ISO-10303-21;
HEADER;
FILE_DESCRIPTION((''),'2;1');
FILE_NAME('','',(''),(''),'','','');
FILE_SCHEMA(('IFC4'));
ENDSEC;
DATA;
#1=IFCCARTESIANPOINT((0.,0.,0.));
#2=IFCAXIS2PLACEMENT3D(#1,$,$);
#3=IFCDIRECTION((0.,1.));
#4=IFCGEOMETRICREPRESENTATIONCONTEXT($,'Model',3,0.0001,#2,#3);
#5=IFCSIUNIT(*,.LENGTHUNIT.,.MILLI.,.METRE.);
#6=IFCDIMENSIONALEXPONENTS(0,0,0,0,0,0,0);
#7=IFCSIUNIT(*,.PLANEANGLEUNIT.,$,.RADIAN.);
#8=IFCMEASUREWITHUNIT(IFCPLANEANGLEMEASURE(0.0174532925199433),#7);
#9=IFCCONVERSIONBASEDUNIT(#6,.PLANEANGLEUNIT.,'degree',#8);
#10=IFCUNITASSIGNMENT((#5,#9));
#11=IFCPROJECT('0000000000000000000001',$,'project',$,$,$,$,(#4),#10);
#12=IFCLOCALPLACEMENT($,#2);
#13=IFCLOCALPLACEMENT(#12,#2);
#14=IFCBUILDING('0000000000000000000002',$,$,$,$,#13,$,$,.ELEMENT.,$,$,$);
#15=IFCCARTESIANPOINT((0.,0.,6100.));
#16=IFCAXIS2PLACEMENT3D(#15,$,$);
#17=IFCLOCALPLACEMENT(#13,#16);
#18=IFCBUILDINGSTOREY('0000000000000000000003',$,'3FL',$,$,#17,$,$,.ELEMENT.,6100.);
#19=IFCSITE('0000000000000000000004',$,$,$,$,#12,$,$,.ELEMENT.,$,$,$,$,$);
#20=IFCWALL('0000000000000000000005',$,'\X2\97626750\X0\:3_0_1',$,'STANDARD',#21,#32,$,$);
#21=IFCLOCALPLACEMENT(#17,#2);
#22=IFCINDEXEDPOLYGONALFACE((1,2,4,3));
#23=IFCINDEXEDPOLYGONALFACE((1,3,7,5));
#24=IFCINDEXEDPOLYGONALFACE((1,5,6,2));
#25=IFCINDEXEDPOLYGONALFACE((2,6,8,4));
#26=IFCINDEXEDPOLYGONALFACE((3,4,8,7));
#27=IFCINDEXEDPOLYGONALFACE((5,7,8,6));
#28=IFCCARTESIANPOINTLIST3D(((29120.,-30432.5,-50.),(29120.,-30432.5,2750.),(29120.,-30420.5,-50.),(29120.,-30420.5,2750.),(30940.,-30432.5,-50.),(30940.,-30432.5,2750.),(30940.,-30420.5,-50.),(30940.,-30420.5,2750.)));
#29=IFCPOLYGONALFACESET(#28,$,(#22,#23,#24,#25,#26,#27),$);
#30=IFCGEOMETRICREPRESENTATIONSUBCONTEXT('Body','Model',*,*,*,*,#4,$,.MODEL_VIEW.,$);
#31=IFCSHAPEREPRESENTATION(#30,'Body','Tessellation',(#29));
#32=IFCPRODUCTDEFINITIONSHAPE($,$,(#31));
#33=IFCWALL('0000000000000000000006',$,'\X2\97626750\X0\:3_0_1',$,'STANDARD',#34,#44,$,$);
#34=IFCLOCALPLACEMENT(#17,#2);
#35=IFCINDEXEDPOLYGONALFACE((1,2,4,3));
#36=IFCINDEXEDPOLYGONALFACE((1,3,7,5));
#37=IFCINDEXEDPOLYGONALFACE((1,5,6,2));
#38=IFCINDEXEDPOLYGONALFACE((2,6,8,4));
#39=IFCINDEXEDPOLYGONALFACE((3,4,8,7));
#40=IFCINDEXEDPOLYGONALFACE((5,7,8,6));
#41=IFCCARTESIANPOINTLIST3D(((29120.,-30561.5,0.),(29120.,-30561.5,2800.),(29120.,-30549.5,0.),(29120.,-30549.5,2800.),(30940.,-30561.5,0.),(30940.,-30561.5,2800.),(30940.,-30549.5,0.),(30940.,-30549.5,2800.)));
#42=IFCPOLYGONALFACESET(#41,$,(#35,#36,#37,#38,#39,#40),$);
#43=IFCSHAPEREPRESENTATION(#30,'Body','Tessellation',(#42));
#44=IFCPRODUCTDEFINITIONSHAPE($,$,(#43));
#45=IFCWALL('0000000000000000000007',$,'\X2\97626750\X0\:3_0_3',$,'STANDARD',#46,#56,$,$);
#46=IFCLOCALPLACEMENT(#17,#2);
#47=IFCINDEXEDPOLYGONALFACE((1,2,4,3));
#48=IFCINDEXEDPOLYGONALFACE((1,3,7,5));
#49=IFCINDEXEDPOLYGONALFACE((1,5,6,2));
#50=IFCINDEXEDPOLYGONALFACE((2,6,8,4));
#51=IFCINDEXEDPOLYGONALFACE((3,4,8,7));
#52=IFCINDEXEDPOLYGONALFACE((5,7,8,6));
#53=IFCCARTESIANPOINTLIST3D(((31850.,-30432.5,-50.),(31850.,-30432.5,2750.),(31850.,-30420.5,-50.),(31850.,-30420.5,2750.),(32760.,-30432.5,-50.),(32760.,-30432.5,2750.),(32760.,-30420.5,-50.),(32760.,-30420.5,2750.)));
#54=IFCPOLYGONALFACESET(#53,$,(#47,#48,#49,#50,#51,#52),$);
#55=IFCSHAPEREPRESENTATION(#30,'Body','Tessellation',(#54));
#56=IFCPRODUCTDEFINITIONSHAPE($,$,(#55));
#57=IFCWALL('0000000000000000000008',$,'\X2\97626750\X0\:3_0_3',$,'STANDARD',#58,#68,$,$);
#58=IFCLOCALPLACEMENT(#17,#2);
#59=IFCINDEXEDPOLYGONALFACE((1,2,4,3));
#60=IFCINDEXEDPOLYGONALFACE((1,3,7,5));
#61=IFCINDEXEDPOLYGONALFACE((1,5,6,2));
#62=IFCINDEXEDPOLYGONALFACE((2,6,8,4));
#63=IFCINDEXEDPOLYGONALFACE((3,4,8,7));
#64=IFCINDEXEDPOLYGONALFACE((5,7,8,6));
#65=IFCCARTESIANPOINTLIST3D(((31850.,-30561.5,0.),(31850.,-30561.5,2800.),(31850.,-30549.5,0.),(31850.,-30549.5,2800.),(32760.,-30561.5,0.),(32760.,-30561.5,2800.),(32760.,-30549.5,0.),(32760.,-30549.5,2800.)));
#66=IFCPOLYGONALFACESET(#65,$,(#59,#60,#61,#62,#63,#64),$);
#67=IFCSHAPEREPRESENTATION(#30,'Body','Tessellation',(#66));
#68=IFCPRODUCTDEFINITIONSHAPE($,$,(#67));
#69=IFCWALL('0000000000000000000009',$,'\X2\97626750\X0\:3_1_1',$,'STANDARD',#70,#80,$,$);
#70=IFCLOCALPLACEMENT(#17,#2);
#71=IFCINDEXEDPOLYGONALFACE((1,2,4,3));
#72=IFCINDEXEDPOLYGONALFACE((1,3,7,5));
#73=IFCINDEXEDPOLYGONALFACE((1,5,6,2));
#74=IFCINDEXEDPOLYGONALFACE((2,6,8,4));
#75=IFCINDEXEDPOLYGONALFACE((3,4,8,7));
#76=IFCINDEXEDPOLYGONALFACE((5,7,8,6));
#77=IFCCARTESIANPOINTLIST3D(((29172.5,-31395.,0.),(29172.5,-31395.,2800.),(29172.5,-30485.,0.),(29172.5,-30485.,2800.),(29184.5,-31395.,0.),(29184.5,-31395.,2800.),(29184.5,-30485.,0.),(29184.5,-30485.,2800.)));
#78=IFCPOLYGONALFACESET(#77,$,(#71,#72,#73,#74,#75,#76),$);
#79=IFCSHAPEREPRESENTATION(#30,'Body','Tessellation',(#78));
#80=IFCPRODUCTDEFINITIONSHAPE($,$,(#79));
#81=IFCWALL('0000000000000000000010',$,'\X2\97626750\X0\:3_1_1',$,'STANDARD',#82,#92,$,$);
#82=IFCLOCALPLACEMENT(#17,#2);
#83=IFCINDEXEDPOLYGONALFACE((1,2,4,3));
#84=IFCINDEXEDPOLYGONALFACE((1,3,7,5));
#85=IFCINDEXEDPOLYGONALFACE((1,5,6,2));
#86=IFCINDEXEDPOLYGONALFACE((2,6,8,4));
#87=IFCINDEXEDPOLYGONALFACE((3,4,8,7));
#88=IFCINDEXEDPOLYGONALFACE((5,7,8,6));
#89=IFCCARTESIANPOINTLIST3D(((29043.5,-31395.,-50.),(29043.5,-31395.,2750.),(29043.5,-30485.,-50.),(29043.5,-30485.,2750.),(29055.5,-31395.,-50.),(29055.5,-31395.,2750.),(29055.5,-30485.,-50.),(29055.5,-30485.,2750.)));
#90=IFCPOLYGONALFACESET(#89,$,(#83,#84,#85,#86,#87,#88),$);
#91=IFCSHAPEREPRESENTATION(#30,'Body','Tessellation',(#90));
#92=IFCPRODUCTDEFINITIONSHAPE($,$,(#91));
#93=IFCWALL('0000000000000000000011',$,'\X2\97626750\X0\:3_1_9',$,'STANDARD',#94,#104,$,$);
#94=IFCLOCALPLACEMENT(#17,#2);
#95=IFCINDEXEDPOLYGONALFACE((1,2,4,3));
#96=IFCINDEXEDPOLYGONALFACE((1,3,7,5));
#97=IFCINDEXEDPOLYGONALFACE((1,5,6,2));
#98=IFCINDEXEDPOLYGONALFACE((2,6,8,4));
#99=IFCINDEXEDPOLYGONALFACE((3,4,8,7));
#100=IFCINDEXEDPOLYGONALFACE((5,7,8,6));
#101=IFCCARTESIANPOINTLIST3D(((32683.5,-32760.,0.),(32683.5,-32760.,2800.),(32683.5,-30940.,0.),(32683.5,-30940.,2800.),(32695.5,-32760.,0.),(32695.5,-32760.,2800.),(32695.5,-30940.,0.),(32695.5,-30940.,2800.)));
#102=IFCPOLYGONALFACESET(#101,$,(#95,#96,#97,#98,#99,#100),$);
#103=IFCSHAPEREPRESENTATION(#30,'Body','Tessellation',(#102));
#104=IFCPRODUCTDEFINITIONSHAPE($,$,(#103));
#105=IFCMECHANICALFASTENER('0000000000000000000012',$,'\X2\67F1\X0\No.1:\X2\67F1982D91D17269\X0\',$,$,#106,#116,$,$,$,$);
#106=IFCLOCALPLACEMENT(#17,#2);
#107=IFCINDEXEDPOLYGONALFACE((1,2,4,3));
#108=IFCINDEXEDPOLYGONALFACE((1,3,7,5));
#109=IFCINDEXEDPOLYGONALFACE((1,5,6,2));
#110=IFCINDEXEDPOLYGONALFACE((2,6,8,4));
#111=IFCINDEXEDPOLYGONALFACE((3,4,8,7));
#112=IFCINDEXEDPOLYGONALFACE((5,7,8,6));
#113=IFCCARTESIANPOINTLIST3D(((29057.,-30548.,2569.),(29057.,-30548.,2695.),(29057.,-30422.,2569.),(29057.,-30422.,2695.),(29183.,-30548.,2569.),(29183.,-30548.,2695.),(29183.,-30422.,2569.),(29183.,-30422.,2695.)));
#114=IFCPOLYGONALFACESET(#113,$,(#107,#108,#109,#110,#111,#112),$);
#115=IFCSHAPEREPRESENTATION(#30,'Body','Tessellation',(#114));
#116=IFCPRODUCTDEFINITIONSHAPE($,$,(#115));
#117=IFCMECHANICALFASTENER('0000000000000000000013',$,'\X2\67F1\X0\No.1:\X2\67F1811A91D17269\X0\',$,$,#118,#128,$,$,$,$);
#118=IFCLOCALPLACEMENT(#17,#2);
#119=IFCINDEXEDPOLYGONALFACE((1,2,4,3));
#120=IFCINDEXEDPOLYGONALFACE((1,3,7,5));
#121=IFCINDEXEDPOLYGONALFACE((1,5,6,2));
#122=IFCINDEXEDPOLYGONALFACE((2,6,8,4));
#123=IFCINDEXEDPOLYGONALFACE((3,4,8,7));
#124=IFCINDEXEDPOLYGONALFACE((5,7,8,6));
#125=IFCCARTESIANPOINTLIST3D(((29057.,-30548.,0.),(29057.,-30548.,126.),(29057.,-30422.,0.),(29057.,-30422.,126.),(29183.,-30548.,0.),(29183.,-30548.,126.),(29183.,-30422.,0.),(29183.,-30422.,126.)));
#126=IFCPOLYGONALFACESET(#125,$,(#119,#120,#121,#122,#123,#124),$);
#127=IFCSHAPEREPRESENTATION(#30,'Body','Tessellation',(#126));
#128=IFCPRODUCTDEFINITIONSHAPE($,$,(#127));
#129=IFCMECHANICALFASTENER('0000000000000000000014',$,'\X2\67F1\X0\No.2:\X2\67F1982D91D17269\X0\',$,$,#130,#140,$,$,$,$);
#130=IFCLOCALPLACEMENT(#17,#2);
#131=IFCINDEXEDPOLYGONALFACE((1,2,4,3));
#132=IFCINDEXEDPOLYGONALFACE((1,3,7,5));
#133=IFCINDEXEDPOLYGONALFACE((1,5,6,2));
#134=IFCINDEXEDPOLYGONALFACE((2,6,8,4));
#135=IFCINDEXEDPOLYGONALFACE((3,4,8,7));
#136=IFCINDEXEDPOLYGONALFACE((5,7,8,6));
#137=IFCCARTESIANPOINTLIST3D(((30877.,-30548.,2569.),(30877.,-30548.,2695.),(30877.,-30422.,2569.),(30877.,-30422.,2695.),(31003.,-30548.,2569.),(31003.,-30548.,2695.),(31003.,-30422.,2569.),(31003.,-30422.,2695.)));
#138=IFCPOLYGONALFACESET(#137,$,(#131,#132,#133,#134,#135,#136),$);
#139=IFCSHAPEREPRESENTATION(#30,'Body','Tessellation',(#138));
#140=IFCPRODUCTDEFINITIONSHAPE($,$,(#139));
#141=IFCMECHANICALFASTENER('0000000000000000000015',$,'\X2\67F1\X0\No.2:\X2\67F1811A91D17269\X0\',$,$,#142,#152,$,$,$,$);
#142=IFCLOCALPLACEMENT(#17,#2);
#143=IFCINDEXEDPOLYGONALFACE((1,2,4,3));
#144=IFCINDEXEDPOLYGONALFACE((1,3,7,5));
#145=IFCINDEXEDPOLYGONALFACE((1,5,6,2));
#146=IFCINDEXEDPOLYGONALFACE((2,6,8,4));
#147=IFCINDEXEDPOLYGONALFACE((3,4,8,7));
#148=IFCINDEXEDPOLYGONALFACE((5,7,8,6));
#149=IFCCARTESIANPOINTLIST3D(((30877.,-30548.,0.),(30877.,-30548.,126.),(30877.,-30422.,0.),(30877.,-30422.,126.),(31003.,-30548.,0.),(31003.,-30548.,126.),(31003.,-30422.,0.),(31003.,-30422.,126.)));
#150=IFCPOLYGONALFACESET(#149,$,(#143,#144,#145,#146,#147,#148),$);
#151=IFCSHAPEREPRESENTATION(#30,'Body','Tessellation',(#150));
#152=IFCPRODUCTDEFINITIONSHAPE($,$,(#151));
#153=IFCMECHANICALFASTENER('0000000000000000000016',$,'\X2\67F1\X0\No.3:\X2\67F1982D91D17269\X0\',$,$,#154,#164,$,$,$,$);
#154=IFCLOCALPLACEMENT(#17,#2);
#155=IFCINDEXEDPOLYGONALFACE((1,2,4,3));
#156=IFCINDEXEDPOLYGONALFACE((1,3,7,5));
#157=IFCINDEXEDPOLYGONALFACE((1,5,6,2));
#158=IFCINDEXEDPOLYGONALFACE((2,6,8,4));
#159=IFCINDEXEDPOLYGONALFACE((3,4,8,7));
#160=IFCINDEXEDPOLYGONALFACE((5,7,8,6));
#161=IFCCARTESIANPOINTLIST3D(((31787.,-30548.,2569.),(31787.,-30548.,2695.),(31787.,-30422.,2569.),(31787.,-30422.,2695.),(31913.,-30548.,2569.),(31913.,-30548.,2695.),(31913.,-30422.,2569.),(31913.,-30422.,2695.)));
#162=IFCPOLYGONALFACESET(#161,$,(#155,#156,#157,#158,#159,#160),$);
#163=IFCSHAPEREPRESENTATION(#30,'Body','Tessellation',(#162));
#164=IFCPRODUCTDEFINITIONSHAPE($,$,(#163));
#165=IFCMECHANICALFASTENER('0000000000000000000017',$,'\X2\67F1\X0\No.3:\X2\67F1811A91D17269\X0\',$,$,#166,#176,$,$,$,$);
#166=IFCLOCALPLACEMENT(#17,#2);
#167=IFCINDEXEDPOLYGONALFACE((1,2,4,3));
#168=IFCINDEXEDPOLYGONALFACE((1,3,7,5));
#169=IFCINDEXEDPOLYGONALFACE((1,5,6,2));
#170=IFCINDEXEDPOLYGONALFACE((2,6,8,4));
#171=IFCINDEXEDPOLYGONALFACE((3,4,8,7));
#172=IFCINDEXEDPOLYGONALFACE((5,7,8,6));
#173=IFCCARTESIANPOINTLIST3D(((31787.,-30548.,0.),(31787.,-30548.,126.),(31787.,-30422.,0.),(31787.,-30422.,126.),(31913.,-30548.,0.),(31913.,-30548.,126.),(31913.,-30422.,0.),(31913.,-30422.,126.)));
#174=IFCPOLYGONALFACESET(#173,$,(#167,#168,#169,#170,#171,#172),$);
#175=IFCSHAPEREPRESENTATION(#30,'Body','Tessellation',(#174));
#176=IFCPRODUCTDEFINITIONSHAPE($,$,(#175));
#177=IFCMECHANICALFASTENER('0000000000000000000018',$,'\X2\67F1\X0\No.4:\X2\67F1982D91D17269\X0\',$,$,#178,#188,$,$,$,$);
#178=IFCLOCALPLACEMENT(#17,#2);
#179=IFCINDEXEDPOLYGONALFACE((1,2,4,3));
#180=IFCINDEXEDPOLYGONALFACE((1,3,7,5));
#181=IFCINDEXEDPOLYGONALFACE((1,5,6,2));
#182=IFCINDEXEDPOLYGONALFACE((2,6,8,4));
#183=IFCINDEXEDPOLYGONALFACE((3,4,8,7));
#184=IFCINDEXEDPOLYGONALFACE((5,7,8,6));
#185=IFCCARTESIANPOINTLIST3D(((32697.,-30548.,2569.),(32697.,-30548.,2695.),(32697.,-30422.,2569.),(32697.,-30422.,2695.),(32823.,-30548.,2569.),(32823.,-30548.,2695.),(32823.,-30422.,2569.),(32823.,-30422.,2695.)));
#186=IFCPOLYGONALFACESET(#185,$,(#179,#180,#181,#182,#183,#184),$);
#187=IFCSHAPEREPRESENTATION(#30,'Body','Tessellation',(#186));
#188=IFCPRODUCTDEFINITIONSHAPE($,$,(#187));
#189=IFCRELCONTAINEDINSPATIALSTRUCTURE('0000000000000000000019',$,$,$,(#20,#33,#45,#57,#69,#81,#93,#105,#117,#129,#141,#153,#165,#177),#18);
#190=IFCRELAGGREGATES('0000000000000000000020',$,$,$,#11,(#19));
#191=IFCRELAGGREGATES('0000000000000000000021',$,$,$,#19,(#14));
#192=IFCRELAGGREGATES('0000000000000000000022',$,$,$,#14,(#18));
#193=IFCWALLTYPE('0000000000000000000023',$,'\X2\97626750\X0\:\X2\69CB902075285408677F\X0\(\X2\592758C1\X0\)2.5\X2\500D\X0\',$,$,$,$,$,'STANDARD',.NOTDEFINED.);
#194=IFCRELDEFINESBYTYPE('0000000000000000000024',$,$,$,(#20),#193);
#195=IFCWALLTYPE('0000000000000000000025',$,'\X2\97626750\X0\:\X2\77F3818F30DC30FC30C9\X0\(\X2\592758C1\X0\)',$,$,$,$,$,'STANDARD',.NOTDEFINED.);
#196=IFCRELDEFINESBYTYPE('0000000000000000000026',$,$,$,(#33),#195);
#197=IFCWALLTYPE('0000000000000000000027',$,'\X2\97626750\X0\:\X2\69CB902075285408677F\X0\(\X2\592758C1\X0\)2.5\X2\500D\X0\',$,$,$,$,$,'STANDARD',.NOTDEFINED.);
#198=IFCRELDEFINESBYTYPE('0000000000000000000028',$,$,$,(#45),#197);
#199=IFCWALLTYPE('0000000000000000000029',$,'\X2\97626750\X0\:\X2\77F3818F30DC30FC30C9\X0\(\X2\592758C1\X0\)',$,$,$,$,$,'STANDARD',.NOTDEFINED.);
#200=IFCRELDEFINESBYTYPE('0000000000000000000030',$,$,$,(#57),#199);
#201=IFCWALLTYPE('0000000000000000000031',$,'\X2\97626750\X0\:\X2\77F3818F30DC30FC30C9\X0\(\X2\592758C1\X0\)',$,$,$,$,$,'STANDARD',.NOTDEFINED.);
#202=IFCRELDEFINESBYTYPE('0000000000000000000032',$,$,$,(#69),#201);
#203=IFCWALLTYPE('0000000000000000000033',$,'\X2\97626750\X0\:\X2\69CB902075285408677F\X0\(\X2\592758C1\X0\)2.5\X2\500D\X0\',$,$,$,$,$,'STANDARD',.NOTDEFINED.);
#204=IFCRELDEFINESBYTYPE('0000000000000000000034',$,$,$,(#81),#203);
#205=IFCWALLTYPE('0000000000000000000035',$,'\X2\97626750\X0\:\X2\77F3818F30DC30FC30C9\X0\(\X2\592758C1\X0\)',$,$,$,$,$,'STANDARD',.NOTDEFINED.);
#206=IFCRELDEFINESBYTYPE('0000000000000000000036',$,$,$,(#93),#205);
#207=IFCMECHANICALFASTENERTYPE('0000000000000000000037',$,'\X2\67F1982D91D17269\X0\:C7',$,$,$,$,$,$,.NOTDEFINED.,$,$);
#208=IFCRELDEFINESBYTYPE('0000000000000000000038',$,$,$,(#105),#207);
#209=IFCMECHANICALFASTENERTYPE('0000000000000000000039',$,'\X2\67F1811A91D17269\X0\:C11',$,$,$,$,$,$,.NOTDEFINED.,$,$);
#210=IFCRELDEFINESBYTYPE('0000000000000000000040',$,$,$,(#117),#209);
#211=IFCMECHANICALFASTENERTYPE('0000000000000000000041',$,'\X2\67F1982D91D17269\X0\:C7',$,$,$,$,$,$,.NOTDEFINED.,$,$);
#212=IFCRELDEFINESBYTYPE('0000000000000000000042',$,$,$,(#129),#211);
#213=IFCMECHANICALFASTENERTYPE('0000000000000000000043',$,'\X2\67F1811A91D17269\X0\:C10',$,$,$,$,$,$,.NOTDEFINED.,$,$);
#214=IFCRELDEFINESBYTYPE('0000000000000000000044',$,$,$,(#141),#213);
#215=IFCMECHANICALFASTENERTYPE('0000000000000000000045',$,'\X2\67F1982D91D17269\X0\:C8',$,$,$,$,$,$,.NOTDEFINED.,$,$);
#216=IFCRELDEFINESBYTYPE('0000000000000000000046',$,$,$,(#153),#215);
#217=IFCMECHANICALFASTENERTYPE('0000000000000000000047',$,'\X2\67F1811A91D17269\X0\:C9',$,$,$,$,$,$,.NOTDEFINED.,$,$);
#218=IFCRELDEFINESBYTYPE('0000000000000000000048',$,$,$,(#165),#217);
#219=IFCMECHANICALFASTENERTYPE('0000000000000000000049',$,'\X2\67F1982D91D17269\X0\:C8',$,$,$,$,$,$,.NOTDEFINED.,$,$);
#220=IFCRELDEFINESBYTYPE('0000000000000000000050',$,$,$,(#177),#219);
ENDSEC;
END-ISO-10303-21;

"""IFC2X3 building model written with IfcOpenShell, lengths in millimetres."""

from ifc_helpers import new_model, entity, si_unit, converted_unit, direction, frame, origin, origin_with_axes, origin_2d, place, context, subcontext, project, spatial, polyline, rectangle, outline, extrude, type_object, element, save


model = new_model("IFC2X3")

# Units and contexts
model_context = context("Model", 3, precision=0.0001, world=origin(), true_north=direction((0.0, 1.0)))
body_context = subcontext(model_context, "Body", "Model", "MODEL_VIEW")
ifc_project = project(units=[si_unit("LENGTHUNIT", "METRE", prefix="MILLI"), converted_unit("PLANEANGLEUNIT", "degree", entity("IfcPlaneAngleMeasure", 0.0174532925199433), si_unit("PLANEANGLEUNIT", "RADIAN"), dimensions=[0, 0, 0, 0, 0, 0, 0])], contexts=[model_context])

# Site, building, storey
site_placement = place(None, origin())
site = spatial("IfcSite", under=ifc_project, at=site_placement, CompositionType="ELEMENT")
building_placement = place(site_placement, origin())
building = spatial("IfcBuilding", under=site, at=building_placement, CompositionType="ELEMENT")
storey_placement = place(building_placement, frame((0.0, 0.0, 6100.0)))
storey = spatial("IfcBuildingStorey", under=building, at=storey_placement, Name="3FL", CompositionType="ELEMENT", Elevation=6100.0)

# Walls
wall_type_1 = type_object("IfcWallType", Name="面材:構造用合板(大壁)2.5倍", ElementType="STANDARD", PredefinedType="NOTDEFINED")
wall_1_placement = place(storey_placement, frame((30030.0, -30420.5, -50.0), z_axis=(0.0, -1.0, 0.0), x_axis=(1.0, 0.0, 0.0)))
element("IfcWall", 1, at=wall_1_placement, inside=storey, type_object=wall_type_1, Name="面材:3_0_1", ObjectType="STANDARD", context=body_context, shape_type="SweptSolid", body=[
    extrude(outline(polyline([(910.0, 0.0, 0.0), (-910.0, 0.0, 0.0), (-910.0, 2800.0, 0.0), (910.0, 2800.0, 0.0), (910.0, 0.0, 0.0)])), origin_with_axes(), (0.0, 0.0, 1.0), 12.0),
])
wall_type_2 = type_object("IfcWallType", Name="面材:石膏ボード(大壁)", ElementType="STANDARD", PredefinedType="NOTDEFINED")
wall_2_placement = place(storey_placement, frame((30030.0, -30549.5, 0.0), z_axis=(0.0, -1.0, 0.0), x_axis=(1.0, 0.0, 0.0)))
element("IfcWall", 2, at=wall_2_placement, inside=storey, type_object=wall_type_2, Name="面材:3_0_1", ObjectType="STANDARD", context=body_context, shape_type="SweptSolid", body=[
    extrude(outline(polyline([(910.0, 0.0, 0.0), (-910.0, 0.0, 0.0), (-910.0, 2800.0, 0.0), (910.0, 2800.0, 0.0), (910.0, 0.0, 0.0)])), origin_with_axes(), (0.0, 0.0, 1.0), 12.0),
])
wall_type_3 = type_object("IfcWallType", Name="面材:構造用合板(大壁)2.5倍", ElementType="STANDARD", PredefinedType="NOTDEFINED")
wall_3_placement = place(storey_placement, frame((32305.0, -30420.5, -50.0), z_axis=(0.0, -1.0, 0.0), x_axis=(1.0, 0.0, 0.0)))
element("IfcWall", 3, at=wall_3_placement, inside=storey, type_object=wall_type_3, Name="面材:3_0_3", ObjectType="STANDARD", context=body_context, shape_type="SweptSolid", body=[
    extrude(outline(polyline([(455.0, 0.0, 0.0), (-455.0, 0.0, 0.0), (-455.0, 2800.0, 0.0), (455.0, 2800.0, 0.0), (455.0, 0.0, 0.0)])), origin_with_axes(), (0.0, 0.0, 1.0), 12.0),
])
wall_type_4 = type_object("IfcWallType", Name="面材:石膏ボード(大壁)", ElementType="STANDARD", PredefinedType="NOTDEFINED")
wall_4_placement = place(storey_placement, frame((32305.0, -30549.5, 0.0), z_axis=(0.0, -1.0, 0.0), x_axis=(1.0, 0.0, 0.0)))
element("IfcWall", 4, at=wall_4_placement, inside=storey, type_object=wall_type_4, Name="面材:3_0_3", ObjectType="STANDARD", context=body_context, shape_type="SweptSolid", body=[
    extrude(outline(polyline([(455.0, 0.0, 0.0), (-455.0, 0.0, 0.0), (-455.0, 2800.0, 0.0), (455.0, 2800.0, 0.0), (455.0, 0.0, 0.0)])), origin_with_axes(), (0.0, 0.0, 1.0), 12.0),
])
wall_type_5 = type_object("IfcWallType", Name="面材:石膏ボード(大壁)", ElementType="STANDARD", PredefinedType="NOTDEFINED")
wall_5_placement = place(storey_placement, frame((29184.5, -30940.0, 0.0), z_axis=(-1.0, 0.0, 0.0), x_axis=(0.0, -1.0, 0.0)))
element("IfcWall", 5, at=wall_5_placement, inside=storey, type_object=wall_type_5, Name="面材:3_1_1", ObjectType="STANDARD", context=body_context, shape_type="SweptSolid", body=[
    extrude(outline(polyline([(455.0, 0.0, 0.0), (-455.0, 0.0, 0.0), (-455.0, 2800.0, 0.0), (455.0, 2800.0, 0.0), (455.0, 0.0, 0.0)])), origin_with_axes(), (0.0, 0.0, 1.0), 12.0),
])
wall_type_6 = type_object("IfcWallType", Name="面材:構造用合板(大壁)2.5倍", ElementType="STANDARD", PredefinedType="NOTDEFINED")
wall_6_placement = place(storey_placement, frame((29055.5, -30940.0, -50.0), z_axis=(-1.0, 0.0, 0.0), x_axis=(0.0, -1.0, 0.0)))
element("IfcWall", 6, at=wall_6_placement, inside=storey, type_object=wall_type_6, Name="面材:3_1_1", ObjectType="STANDARD", context=body_context, shape_type="SweptSolid", body=[
    extrude(outline(polyline([(455.0, 0.0, 0.0), (-455.0, 0.0, 0.0), (-455.0, 2800.0, 0.0), (455.0, 2800.0, 0.0), (455.0, 0.0, 0.0)])), origin_with_axes(), (0.0, 0.0, 1.0), 12.0),
])
wall_type_7 = type_object("IfcWallType", Name="面材:石膏ボード(大壁)", ElementType="STANDARD", PredefinedType="NOTDEFINED")
wall_7_placement = place(storey_placement, frame((32695.5, -31850.0, 0.0), z_axis=(-1.0, 0.0, 0.0), x_axis=(0.0, -1.0, 0.0)))
element("IfcWall", 7, at=wall_7_placement, inside=storey, type_object=wall_type_7, Name="面材:3_1_9", ObjectType="STANDARD", context=body_context, shape_type="SweptSolid", body=[
    extrude(outline(polyline([(910.0, 0.0, 0.0), (-910.0, 0.0, 0.0), (-910.0, 2800.0, 0.0), (910.0, 2800.0, 0.0), (910.0, 0.0, 0.0)])), origin_with_axes(), (0.0, 0.0, 1.0), 12.0),
])

# Mechanical fasteners
mechanical_fastener_type_1 = type_object("IfcMechanicalFastenerType", Name="柱頭金物:C7")
mechanical_fastener_1_placement = place(storey_placement, frame((29120.0, -30485.0, 2569.0)))
element("IfcMechanicalFastener", 8, at=mechanical_fastener_1_placement, inside=storey, type_object=mechanical_fastener_type_1, Name="柱No.1:柱頭金物", context=body_context, shape_type="SweptSolid", body=[
    extrude(rectangle(XDim=126.0, YDim=126.0, at=origin_2d()), origin_with_axes(), (0.0, 0.0, 1.0), 126.0),
])
mechanical_fastener_type_2 = type_object("IfcMechanicalFastenerType", Name="柱脚金物:C11")
mechanical_fastener_2_placement = place(storey_placement, frame((29120.0, -30485.0, 0.0)))
element("IfcMechanicalFastener", 9, at=mechanical_fastener_2_placement, inside=storey, type_object=mechanical_fastener_type_2, Name="柱No.1:柱脚金物", context=body_context, shape_type="SweptSolid", body=[
    extrude(rectangle(XDim=126.0, YDim=126.0, at=origin_2d()), origin_with_axes(), (0.0, 0.0, 1.0), 126.0),
])
mechanical_fastener_type_3 = type_object("IfcMechanicalFastenerType", Name="柱頭金物:C7")
mechanical_fastener_3_placement = place(storey_placement, frame((30940.0, -30485.0, 2569.0)))
element("IfcMechanicalFastener", 10, at=mechanical_fastener_3_placement, inside=storey, type_object=mechanical_fastener_type_3, Name="柱No.2:柱頭金物", context=body_context, shape_type="SweptSolid", body=[
    extrude(rectangle(XDim=126.0, YDim=126.0, at=origin_2d()), origin_with_axes(), (0.0, 0.0, 1.0), 126.0),
])
mechanical_fastener_type_4 = type_object("IfcMechanicalFastenerType", Name="柱脚金物:C10")
mechanical_fastener_4_placement = place(storey_placement, frame((30940.0, -30485.0, 0.0)))
element("IfcMechanicalFastener", 11, at=mechanical_fastener_4_placement, inside=storey, type_object=mechanical_fastener_type_4, Name="柱No.2:柱脚金物", context=body_context, shape_type="SweptSolid", body=[
    extrude(rectangle(XDim=126.0, YDim=126.0, at=origin_2d()), origin_with_axes(), (0.0, 0.0, 1.0), 126.0),
])
mechanical_fastener_type_5 = type_object("IfcMechanicalFastenerType", Name="柱頭金物:C8")
mechanical_fastener_5_placement = place(storey_placement, frame((31850.0, -30485.0, 2569.0)))
element("IfcMechanicalFastener", 12, at=mechanical_fastener_5_placement, inside=storey, type_object=mechanical_fastener_type_5, Name="柱No.3:柱頭金物", context=body_context, shape_type="SweptSolid", body=[
    extrude(rectangle(XDim=126.0, YDim=126.0, at=origin_2d()), origin_with_axes(), (0.0, 0.0, 1.0), 126.0),
])
mechanical_fastener_type_6 = type_object("IfcMechanicalFastenerType", Name="柱脚金物:C9")
mechanical_fastener_6_placement = place(storey_placement, frame((31850.0, -30485.0, 0.0)))
element("IfcMechanicalFastener", 13, at=mechanical_fastener_6_placement, inside=storey, type_object=mechanical_fastener_type_6, Name="柱No.3:柱脚金物", context=body_context, shape_type="SweptSolid", body=[
    extrude(rectangle(XDim=126.0, YDim=126.0, at=origin_2d()), origin_with_axes(), (0.0, 0.0, 1.0), 126.0),
])
mechanical_fastener_type_7 = type_object("IfcMechanicalFastenerType", Name="柱頭金物:C8")
mechanical_fastener_7_placement = place(storey_placement, frame((32760.0, -30485.0, 2569.0)))
element("IfcMechanicalFastener", 14, at=mechanical_fastener_7_placement, inside=storey, type_object=mechanical_fastener_type_7, Name="柱No.4:柱頭金物", context=body_context, shape_type="SweptSolid", body=[
    extrude(rectangle(XDim=126.0, YDim=126.0, at=origin_2d()), origin_with_axes(), (0.0, 0.0, 1.0), 126.0),
])

save(model, "model.ifc")
